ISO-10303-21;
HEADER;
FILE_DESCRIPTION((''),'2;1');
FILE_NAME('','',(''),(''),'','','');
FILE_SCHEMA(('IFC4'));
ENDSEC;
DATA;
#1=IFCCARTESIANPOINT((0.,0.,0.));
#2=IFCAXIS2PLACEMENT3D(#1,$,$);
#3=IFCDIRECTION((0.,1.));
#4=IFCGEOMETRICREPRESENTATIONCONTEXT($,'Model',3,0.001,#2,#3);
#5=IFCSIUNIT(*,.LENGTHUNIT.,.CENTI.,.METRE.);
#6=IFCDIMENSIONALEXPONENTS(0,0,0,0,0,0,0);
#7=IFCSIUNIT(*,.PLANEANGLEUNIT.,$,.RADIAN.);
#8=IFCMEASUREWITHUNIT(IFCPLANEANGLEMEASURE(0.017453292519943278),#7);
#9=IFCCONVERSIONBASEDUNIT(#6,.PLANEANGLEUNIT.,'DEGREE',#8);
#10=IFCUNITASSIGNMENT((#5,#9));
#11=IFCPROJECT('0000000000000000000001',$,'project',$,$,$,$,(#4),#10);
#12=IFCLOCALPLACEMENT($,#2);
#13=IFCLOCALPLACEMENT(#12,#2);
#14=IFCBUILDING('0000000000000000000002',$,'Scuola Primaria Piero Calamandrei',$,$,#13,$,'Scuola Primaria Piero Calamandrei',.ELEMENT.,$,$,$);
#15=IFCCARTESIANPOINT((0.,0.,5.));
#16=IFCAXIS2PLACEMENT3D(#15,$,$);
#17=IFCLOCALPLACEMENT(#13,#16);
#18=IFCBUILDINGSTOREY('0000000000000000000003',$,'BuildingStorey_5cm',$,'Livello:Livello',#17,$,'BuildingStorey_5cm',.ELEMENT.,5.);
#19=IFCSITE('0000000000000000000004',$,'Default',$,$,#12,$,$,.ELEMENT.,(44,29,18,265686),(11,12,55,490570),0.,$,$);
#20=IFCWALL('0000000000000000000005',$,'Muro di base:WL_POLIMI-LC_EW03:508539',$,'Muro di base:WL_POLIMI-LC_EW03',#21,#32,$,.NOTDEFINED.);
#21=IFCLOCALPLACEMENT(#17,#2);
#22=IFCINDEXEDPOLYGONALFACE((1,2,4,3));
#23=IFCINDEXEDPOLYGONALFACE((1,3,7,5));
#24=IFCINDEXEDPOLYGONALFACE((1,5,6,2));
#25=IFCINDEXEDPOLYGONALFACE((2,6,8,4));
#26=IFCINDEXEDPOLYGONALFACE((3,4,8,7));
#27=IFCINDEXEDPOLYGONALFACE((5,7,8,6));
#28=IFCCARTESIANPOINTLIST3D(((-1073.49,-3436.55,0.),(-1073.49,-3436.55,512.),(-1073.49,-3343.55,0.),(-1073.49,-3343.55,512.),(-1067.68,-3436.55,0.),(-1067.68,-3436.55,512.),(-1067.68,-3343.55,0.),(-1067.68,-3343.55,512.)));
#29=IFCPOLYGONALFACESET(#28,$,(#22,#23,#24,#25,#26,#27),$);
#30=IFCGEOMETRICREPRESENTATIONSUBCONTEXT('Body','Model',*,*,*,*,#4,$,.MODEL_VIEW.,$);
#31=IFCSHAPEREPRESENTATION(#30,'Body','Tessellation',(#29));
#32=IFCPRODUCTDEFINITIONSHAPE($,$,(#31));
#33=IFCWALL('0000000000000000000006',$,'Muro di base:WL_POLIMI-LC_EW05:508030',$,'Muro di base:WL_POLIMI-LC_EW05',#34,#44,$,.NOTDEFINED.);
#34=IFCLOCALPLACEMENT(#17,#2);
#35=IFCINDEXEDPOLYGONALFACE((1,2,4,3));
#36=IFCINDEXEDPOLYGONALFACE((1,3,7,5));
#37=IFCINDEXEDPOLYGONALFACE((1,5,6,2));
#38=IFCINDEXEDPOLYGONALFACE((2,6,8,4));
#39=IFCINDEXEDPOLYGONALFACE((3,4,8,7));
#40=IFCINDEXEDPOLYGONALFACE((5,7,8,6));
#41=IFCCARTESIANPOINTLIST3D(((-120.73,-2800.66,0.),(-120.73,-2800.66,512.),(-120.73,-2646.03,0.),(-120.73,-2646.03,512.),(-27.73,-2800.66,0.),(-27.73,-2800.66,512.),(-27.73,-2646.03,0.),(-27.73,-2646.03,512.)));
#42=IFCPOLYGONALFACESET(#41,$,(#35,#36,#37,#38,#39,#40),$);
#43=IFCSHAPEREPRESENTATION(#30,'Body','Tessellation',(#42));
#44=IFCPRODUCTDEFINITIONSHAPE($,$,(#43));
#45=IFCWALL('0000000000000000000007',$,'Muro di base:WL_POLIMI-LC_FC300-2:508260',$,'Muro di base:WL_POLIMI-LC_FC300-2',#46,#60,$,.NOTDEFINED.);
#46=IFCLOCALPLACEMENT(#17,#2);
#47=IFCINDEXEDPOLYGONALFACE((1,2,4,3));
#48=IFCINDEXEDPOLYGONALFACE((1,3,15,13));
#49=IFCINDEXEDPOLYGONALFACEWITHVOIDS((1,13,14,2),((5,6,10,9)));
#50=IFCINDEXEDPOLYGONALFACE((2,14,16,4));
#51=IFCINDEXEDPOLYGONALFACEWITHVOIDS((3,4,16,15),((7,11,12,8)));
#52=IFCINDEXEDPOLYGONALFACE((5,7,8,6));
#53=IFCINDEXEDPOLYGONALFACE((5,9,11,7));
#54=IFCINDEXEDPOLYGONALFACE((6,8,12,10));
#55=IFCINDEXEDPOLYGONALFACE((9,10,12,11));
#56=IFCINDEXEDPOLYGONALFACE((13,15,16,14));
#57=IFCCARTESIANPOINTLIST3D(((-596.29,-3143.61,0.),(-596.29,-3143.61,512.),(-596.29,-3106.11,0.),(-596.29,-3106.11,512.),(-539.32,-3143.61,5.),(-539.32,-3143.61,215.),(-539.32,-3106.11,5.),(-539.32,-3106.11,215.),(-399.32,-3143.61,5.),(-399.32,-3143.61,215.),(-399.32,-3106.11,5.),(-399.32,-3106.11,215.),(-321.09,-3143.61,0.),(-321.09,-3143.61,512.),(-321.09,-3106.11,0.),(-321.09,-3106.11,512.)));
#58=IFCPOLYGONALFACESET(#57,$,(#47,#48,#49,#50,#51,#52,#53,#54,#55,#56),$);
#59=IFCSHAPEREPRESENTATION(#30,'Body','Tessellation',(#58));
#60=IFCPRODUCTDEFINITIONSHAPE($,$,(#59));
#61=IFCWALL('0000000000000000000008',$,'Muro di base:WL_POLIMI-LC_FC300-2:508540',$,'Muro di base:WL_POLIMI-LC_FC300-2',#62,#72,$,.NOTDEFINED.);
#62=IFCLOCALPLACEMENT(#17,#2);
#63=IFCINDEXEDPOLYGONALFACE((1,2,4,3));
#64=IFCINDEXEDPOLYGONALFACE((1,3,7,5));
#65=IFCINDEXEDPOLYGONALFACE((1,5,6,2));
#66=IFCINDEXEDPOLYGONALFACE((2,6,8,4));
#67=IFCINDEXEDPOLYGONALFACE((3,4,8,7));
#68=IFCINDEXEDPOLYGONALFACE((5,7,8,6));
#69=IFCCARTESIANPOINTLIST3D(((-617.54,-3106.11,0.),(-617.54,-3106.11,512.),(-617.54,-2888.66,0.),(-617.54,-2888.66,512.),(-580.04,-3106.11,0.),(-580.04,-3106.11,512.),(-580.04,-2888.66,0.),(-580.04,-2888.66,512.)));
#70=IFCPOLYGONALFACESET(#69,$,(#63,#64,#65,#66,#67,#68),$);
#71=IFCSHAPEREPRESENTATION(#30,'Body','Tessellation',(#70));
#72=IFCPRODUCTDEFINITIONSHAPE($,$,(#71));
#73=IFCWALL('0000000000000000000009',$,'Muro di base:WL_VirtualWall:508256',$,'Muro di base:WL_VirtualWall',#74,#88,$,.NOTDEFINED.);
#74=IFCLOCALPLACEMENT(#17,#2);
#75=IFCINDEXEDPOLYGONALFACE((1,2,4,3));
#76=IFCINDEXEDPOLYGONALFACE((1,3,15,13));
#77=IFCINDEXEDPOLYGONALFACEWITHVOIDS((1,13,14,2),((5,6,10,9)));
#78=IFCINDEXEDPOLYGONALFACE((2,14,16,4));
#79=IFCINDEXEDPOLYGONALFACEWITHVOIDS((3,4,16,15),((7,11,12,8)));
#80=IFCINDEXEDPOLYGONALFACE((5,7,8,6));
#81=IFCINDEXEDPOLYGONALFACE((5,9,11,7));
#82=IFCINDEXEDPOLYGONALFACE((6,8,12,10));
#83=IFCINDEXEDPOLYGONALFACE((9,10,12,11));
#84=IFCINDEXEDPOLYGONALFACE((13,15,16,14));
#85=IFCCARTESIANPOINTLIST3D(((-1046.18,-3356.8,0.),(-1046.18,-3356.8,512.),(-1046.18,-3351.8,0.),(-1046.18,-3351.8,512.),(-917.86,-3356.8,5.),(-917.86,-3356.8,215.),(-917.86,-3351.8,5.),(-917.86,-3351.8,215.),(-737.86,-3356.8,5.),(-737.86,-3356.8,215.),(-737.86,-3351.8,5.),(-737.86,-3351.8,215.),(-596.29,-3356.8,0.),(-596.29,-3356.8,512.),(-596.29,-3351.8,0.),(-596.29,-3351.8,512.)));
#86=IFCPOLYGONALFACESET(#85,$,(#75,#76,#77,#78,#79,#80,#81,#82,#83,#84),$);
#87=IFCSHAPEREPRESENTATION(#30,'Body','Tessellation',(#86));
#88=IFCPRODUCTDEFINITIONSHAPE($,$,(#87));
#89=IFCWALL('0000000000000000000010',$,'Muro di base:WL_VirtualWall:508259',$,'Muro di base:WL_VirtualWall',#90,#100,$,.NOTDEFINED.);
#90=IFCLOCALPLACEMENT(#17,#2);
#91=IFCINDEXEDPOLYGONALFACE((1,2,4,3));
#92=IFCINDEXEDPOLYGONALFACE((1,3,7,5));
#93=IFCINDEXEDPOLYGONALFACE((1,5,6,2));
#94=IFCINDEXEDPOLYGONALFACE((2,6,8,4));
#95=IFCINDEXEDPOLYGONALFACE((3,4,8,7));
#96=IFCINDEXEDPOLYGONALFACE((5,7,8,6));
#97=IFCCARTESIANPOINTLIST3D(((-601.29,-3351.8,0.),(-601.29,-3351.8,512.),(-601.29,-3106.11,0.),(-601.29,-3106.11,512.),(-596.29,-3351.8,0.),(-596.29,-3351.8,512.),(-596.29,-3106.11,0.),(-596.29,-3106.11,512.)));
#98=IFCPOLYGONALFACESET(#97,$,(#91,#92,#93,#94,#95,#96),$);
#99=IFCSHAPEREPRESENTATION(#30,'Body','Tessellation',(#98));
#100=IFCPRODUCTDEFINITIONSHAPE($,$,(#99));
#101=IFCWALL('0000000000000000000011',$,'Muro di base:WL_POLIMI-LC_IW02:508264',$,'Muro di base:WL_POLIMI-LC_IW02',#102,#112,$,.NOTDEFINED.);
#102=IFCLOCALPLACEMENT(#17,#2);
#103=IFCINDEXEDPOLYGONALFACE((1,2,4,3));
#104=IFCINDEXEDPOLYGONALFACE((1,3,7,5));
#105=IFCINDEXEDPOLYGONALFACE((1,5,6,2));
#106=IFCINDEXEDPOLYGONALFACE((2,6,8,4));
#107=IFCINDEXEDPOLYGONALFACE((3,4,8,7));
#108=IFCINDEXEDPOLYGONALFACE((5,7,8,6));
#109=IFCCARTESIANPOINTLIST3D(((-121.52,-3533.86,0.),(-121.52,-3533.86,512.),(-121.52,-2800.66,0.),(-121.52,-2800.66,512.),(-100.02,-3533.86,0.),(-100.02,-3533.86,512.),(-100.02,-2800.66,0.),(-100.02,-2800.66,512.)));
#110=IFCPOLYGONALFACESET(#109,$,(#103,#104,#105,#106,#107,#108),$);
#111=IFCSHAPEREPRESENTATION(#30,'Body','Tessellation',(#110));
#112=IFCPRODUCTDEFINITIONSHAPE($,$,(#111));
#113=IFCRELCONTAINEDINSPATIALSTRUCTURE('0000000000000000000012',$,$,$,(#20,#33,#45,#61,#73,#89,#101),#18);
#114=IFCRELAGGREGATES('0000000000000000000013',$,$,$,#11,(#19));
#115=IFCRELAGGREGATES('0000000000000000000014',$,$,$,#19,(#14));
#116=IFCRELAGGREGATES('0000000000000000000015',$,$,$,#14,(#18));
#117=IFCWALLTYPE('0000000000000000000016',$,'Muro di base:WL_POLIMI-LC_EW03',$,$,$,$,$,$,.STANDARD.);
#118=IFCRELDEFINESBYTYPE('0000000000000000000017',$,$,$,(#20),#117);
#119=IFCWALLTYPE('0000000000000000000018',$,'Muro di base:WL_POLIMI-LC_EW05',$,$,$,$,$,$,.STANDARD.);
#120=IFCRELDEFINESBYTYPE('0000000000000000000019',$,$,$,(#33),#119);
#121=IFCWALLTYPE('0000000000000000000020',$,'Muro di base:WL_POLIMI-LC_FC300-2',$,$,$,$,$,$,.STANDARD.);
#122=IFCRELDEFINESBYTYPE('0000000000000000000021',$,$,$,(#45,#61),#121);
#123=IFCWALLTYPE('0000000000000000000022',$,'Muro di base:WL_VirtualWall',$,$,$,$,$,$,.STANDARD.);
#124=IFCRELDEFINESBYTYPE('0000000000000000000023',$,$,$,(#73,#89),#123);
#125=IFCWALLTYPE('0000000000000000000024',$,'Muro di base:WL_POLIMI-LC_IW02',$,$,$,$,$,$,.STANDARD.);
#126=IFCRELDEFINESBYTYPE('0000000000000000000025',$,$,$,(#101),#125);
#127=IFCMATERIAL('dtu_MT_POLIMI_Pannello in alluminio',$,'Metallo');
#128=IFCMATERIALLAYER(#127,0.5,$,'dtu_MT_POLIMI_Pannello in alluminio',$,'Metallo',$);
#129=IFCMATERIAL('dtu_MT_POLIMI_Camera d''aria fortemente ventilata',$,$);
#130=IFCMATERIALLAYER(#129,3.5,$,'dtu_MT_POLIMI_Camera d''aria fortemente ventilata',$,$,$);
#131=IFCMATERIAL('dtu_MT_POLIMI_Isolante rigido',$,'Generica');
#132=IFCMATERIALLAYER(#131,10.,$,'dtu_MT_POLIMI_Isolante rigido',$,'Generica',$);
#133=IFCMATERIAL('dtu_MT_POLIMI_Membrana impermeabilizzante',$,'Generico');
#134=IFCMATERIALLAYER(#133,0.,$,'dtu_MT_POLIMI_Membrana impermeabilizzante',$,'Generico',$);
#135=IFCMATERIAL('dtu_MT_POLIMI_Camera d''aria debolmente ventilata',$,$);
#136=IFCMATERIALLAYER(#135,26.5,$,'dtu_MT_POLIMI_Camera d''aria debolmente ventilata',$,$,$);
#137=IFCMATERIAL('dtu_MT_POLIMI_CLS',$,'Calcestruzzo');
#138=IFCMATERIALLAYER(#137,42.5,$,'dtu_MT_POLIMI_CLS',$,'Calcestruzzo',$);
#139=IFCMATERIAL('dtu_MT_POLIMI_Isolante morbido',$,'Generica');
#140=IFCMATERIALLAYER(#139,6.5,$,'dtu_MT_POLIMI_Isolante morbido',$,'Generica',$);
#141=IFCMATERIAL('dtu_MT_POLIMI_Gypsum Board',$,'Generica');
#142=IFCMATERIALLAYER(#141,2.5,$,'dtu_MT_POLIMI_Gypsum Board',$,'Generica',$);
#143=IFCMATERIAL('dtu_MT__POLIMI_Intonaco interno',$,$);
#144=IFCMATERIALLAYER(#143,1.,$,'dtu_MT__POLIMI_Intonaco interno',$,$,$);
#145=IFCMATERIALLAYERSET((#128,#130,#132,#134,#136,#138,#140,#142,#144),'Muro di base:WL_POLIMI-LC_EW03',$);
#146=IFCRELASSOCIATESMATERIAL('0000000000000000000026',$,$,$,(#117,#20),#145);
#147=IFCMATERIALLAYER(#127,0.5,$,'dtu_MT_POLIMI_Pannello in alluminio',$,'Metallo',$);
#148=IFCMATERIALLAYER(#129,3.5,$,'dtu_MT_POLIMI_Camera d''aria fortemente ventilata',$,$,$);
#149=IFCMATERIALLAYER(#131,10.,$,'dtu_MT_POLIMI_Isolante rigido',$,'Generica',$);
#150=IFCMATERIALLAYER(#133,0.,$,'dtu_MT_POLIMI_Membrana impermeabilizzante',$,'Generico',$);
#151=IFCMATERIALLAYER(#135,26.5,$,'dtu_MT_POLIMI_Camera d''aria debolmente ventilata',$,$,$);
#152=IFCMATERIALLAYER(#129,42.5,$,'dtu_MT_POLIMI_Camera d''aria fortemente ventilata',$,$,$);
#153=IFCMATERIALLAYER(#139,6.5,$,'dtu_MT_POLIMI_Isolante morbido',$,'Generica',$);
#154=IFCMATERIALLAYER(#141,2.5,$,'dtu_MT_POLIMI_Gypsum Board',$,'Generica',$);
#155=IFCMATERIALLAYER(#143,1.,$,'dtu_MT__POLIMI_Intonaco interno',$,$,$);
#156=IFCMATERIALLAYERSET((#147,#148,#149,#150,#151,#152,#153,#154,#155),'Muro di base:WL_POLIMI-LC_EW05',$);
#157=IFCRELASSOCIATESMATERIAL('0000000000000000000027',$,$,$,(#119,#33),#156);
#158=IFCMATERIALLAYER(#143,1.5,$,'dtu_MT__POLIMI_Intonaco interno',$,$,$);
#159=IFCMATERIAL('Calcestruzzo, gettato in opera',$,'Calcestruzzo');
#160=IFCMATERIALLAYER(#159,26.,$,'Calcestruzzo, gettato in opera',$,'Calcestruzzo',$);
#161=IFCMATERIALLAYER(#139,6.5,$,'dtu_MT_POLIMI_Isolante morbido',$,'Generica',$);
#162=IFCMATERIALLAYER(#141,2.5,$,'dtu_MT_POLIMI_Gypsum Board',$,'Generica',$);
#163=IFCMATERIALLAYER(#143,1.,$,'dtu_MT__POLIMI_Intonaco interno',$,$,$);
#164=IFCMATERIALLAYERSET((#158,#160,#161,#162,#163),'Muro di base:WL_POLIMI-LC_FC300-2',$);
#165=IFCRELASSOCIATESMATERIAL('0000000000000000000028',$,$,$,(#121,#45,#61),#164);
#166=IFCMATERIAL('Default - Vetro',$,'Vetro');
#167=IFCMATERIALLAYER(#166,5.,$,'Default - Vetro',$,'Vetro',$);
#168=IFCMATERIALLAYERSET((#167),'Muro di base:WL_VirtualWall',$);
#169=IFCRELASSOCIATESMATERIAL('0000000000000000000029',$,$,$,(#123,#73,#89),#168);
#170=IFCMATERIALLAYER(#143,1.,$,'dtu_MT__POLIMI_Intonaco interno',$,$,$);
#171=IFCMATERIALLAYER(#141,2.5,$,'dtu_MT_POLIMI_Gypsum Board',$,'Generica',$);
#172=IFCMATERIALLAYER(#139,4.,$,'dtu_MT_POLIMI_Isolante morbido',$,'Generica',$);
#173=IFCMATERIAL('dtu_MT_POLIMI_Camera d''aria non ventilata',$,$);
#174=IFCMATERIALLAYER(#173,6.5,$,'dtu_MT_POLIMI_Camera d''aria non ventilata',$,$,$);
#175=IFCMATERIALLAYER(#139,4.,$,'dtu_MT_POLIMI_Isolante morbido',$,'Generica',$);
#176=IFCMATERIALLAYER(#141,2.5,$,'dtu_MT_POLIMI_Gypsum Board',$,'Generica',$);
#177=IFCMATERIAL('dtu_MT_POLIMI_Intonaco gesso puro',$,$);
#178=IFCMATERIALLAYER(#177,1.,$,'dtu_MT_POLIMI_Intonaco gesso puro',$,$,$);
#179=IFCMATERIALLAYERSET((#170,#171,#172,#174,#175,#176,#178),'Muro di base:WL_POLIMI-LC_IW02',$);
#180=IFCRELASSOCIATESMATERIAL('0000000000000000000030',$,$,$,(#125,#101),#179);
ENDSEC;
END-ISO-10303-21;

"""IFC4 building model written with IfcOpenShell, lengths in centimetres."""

from ifc_helpers import new_model, entity, si_unit, converted_unit, direction, frame, frame_2d, origin, place, context, subcontext, project, spatial, rectangle, extrude, material, layer, layer_set, layer_usage, type_object, element, save


model = new_model("IFC4")

# Units and contexts
model_context = context("Model", 3, precision=0.001, world=origin(), true_north=direction((0.0, 1.0)))
body_context = subcontext(model_context, "Body", "Model", "MODEL_VIEW")
ifc_project = project(units=[si_unit("LENGTHUNIT", "METRE", prefix="CENTI"), converted_unit("PLANEANGLEUNIT", "DEGREE", entity("IfcPlaneAngleMeasure", 0.017453292519943278), si_unit("PLANEANGLEUNIT", "RADIAN"), dimensions=[0, 0, 0, 0, 0, 0, 0])], contexts=[model_context])

# Site, building, storey
site_placement = place(None, origin())
site = spatial("IfcSite", under=ifc_project, at=site_placement, Name="Default", CompositionType="ELEMENT", RefLatitude=(44, 29, 18, 265686), RefLongitude=(11, 12, 55, 490570), RefElevation=0.0)
building_placement = place(site_placement, origin())
building = spatial("IfcBuilding", under=site, at=building_placement, Name="Scuola Primaria Piero Calamandrei", LongName="Scuola Primaria Piero Calamandrei", CompositionType="ELEMENT")
storey_placement = place(building_placement, frame((0.0, 0.0, 5.0)))
storey = spatial("IfcBuildingStorey", under=building, at=storey_placement, Name="BuildingStorey_5cm", ObjectType="Livello:Livello", LongName="BuildingStorey_5cm", CompositionType="ELEMENT", Elevation=5.0)

# Shared definitions
ifc_material_1 = material(Name="Default - Vetro", Category="Vetro")

# Walls
ifc_material_2 = material(Name="dtu_MT_POLIMI_Pannello in alluminio", Category="Metallo")
ifc_layer_1 = layer(ifc_material_2, 0.5, Name="dtu_MT_POLIMI_Pannello in alluminio", Category="Metallo")
ifc_material_3 = material(Name="dtu_MT_POLIMI_Camera d'aria fortemente ventilata")
ifc_layer_2 = layer(ifc_material_3, 3.5, Name="dtu_MT_POLIMI_Camera d'aria fortemente ventilata")
ifc_material_4 = material(Name="dtu_MT_POLIMI_Isolante rigido", Category="Generica")
ifc_layer_3 = layer(ifc_material_4, 10.0, Name="dtu_MT_POLIMI_Isolante rigido", Category="Generica")
ifc_material_5 = material(Name="dtu_MT_POLIMI_Membrana impermeabilizzante", Category="Generico")
ifc_layer_4 = layer(ifc_material_5, 0.0, Name="dtu_MT_POLIMI_Membrana impermeabilizzante", Category="Generico")
ifc_material_6 = material(Name="dtu_MT_POLIMI_Camera d'aria debolmente ventilata")
ifc_layer_5 = layer(ifc_material_6, 26.5, Name="dtu_MT_POLIMI_Camera d'aria debolmente ventilata")
ifc_material_7 = material(Name="dtu_MT_POLIMI_CLS", Category="Calcestruzzo")
ifc_layer_6 = layer(ifc_material_7, 42.5, Name="dtu_MT_POLIMI_CLS", Category="Calcestruzzo")
ifc_material_8 = material(Name="dtu_MT_POLIMI_Isolante morbido", Category="Generica")
ifc_layer_7 = layer(ifc_material_8, 6.5, Name="dtu_MT_POLIMI_Isolante morbido", Category="Generica")
ifc_material_9 = material(Name="dtu_MT_POLIMI_Gypsum Board", Category="Generica")
ifc_layer_8 = layer(ifc_material_9, 2.5, Name="dtu_MT_POLIMI_Gypsum Board", Category="Generica")
ifc_material_10 = material(Name="dtu_MT__POLIMI_Intonaco interno")
ifc_layer_9 = layer(ifc_material_10, 1.0, Name="dtu_MT__POLIMI_Intonaco interno")
ifc_layer_set_1 = layer_set([ifc_layer_1, ifc_layer_2, ifc_layer_3, ifc_layer_4, ifc_layer_5, ifc_layer_6, ifc_layer_7, ifc_layer_8, ifc_layer_9], Name="Muro di base:WL_POLIMI-LC_EW03")
wall_type_1 = type_object("IfcWallType", Name="Muro di base:WL_POLIMI-LC_EW03", PredefinedType="STANDARD", material=ifc_layer_set_1)
ifc_layer_usage_1 = layer_usage(ifc_layer_set_1, "AXIS2", "NEGATIVE", 46.5)
wall_1_placement = place(storey_placement, frame((-1073.49, -3390.05, 0.0)))
element("IfcWall", 1, at=wall_1_placement, inside=storey, type_object=wall_type_1, material=ifc_layer_usage_1, Name="Muro di base:WL_POLIMI-LC_EW03:508539", ObjectType="Muro di base:WL_POLIMI-LC_EW03", PredefinedType="NOTDEFINED", context=body_context, shape_type="SweptSolid", body=[
    extrude(rectangle(XDim=5.81, YDim=93.0, at=frame_2d((2.9, 0.0), x_axis=(-1.0, 0.0))), origin(), (0.0, 0.0, 1.0), 512.0),
])
ifc_layer_10 = layer(ifc_material_2, 0.5, Name="dtu_MT_POLIMI_Pannello in alluminio", Category="Metallo")
ifc_layer_11 = layer(ifc_material_3, 3.5, Name="dtu_MT_POLIMI_Camera d'aria fortemente ventilata")
ifc_layer_12 = layer(ifc_material_4, 10.0, Name="dtu_MT_POLIMI_Isolante rigido", Category="Generica")
ifc_layer_13 = layer(ifc_material_5, 0.0, Name="dtu_MT_POLIMI_Membrana impermeabilizzante", Category="Generico")
ifc_layer_14 = layer(ifc_material_6, 26.5, Name="dtu_MT_POLIMI_Camera d'aria debolmente ventilata")
ifc_layer_15 = layer(ifc_material_3, 42.5, Name="dtu_MT_POLIMI_Camera d'aria fortemente ventilata")
ifc_layer_16 = layer(ifc_material_8, 6.5, Name="dtu_MT_POLIMI_Isolante morbido", Category="Generica")
ifc_layer_17 = layer(ifc_material_9, 2.5, Name="dtu_MT_POLIMI_Gypsum Board", Category="Generica")
ifc_layer_18 = layer(ifc_material_10, 1.0, Name="dtu_MT__POLIMI_Intonaco interno")
ifc_layer_set_2 = layer_set([ifc_layer_10, ifc_layer_11, ifc_layer_12, ifc_layer_13, ifc_layer_14, ifc_layer_15, ifc_layer_16, ifc_layer_17, ifc_layer_18], Name="Muro di base:WL_POLIMI-LC_EW05")
ifc_layer_usage_2 = layer_usage(ifc_layer_set_2, "AXIS2", "NEGATIVE", 46.5)
wall_type_2 = type_object("IfcWallType", Name="Muro di base:WL_POLIMI-LC_EW05", PredefinedType="STANDARD", material=ifc_layer_set_2)
wall_2_placement = place(storey_placement, frame((-74.23, -2800.66, 0.0), z_axis=(0.0, 0.0, 1.0), x_axis=(0.0, 1.0, 0.0)))
element("IfcWall", 2, at=wall_2_placement, inside=storey, type_object=wall_type_2, material=ifc_layer_usage_2, Name="Muro di base:WL_POLIMI-LC_EW05:508030", ObjectType="Muro di base:WL_POLIMI-LC_EW05", PredefinedType="NOTDEFINED", context=body_context, shape_type="SweptSolid", body=[
    extrude(rectangle(XDim=154.63, YDim=93.0, at=frame_2d((77.32, 0.0), x_axis=(-1.0, 0.0))), origin(), (0.0, 0.0, 1.0), 512.0),
])

# Wall, opening
ifc_layer_19 = layer(ifc_material_10, 1.5, Name="dtu_MT__POLIMI_Intonaco interno")
ifc_material_11 = material(Name="Calcestruzzo, gettato in opera", Category="Calcestruzzo")
ifc_layer_20 = layer(ifc_material_11, 26.0, Name="Calcestruzzo, gettato in opera", Category="Calcestruzzo")
ifc_layer_21 = layer(ifc_material_8, 6.5, Name="dtu_MT_POLIMI_Isolante morbido", Category="Generica")
ifc_layer_22 = layer(ifc_material_9, 2.5, Name="dtu_MT_POLIMI_Gypsum Board", Category="Generica")
ifc_layer_23 = layer(ifc_material_10, 1.0, Name="dtu_MT__POLIMI_Intonaco interno")
ifc_layer_set_3 = layer_set([ifc_layer_19, ifc_layer_20, ifc_layer_21, ifc_layer_22, ifc_layer_23], Name="Muro di base:WL_POLIMI-LC_FC300-2")
ifc_layer_usage_3 = layer_usage(ifc_layer_set_3, "AXIS2", "NEGATIVE", 18.75)
wall_type_3 = type_object("IfcWallType", Name="Muro di base:WL_POLIMI-LC_FC300-2", PredefinedType="STANDARD", material=ifc_layer_set_3)
wall_3_placement = place(storey_placement, frame((-596.29, -3124.86, 0.0)))
wall_3 = element("IfcWall", 3, at=wall_3_placement, inside=storey, type_object=wall_type_3, material=ifc_layer_usage_3, Name="Muro di base:WL_POLIMI-LC_FC300-2:508260", ObjectType="Muro di base:WL_POLIMI-LC_FC300-2", PredefinedType="NOTDEFINED", context=body_context, shape_type="SweptSolid", body=[
    extrude(rectangle(XDim=275.2, YDim=37.5, at=frame_2d((137.6, 0.0), x_axis=(-1.0, 0.0))), origin(), (0.0, 0.0, 1.0), 512.0),
])
opening_1_placement = place(wall_3_placement, frame((56.98, -18.75, 5.0)))
element("IfcOpeningElement", 4, at=opening_1_placement, cuts=wall_3, PredefinedType="OPENING", context=body_context, shape_type="SweptSolid", body=[
    extrude(rectangle(XDim=210.0, YDim=140.0, at=frame_2d((105.0, 70.0), x_axis=(1.0, 0.0))), frame((0.0, 0.0, 0.0), z_axis=(0.0, 1.0, 0.0), x_axis=(0.0, 0.0, 1.0)), (0.0, 0.0, 1.0), 37.5),
])

# Wall
ifc_layer_usage_4 = layer_usage(ifc_layer_set_3, "AXIS2", "NEGATIVE", 18.75)
wall_4_placement = place(storey_placement, frame((-598.79, -2888.66, 0.0), z_axis=(0.0, 0.0, 1.0), x_axis=(0.0, -1.0, 0.0)))
element("IfcWall", 5, at=wall_4_placement, inside=storey, type_object=wall_type_3, material=ifc_layer_usage_4, Name="Muro di base:WL_POLIMI-LC_FC300-2:508540", ObjectType="Muro di base:WL_POLIMI-LC_FC300-2", PredefinedType="NOTDEFINED", context=body_context, shape_type="SweptSolid", body=[
    extrude(rectangle(XDim=217.44, YDim=37.5, at=frame_2d((108.72, 0.0), x_axis=(-1.0, 0.0))), origin(), (0.0, 0.0, 1.0), 512.0),
])

# Wall, opening
ifc_layer_24 = layer(ifc_material_1, 5.0, Name="Default - Vetro", Category="Vetro")
ifc_layer_set_4 = layer_set([ifc_layer_24], Name="Muro di base:WL_VirtualWall")
ifc_layer_usage_5 = layer_usage(ifc_layer_set_4, "AXIS2", "NEGATIVE", 2.5)
wall_type_4 = type_object("IfcWallType", Name="Muro di base:WL_VirtualWall", PredefinedType="STANDARD", material=ifc_layer_set_4)
wall_5_placement = place(storey_placement, frame((-1046.18, -3354.3, 0.0)))
wall_5 = element("IfcWall", 6, at=wall_5_placement, inside=storey, type_object=wall_type_4, material=ifc_layer_usage_5, Name="Muro di base:WL_VirtualWall:508256", ObjectType="Muro di base:WL_VirtualWall", PredefinedType="NOTDEFINED", context=body_context, shape_type="SweptSolid", body=[
    extrude(rectangle(XDim=449.89, YDim=5.0, at=frame_2d((224.95, 0.0), x_axis=(-1.0, 0.0))), origin(), (0.0, 0.0, 1.0), 512.0),
])
opening_2_placement = place(wall_5_placement, frame((128.32, -2.5, 5.0)))
element("IfcOpeningElement", 7, at=opening_2_placement, cuts=wall_5, PredefinedType="OPENING", context=body_context, shape_type="SweptSolid", body=[
    extrude(rectangle(XDim=210.0, YDim=180.0, at=frame_2d((105.0, 90.0), x_axis=(1.0, 0.0))), frame((0.0, 0.0, 0.0), z_axis=(0.0, 1.0, 0.0), x_axis=(0.0, 0.0, 1.0)), (0.0, 0.0, 1.0), 5.0),
])

# Walls
ifc_layer_usage_6 = layer_usage(ifc_layer_set_4, "AXIS2", "NEGATIVE", 2.5)
wall_6_placement = place(storey_placement, frame((-598.79, -3351.8, 0.0), z_axis=(0.0, 0.0, 1.0), x_axis=(0.0, 1.0, 0.0)))
element("IfcWall", 8, at=wall_6_placement, inside=storey, type_object=wall_type_4, material=ifc_layer_usage_6, Name="Muro di base:WL_VirtualWall:508259", ObjectType="Muro di base:WL_VirtualWall", PredefinedType="NOTDEFINED", context=body_context, shape_type="SweptSolid", body=[
    extrude(rectangle(XDim=245.69, YDim=5.0, at=frame_2d((122.84, 0.0), x_axis=(-1.0, 0.0))), origin(), (0.0, 0.0, 1.0), 512.0),
])
ifc_layer_25 = layer(ifc_material_10, 1.0, Name="dtu_MT__POLIMI_Intonaco interno")
ifc_layer_26 = layer(ifc_material_9, 2.5, Name="dtu_MT_POLIMI_Gypsum Board", Category="Generica")
ifc_layer_27 = layer(ifc_material_8, 4.0, Name="dtu_MT_POLIMI_Isolante morbido", Category="Generica")
ifc_material_12 = material(Name="dtu_MT_POLIMI_Camera d'aria non ventilata")
ifc_layer_28 = layer(ifc_material_12, 6.5, Name="dtu_MT_POLIMI_Camera d'aria non ventilata")
ifc_layer_29 = layer(ifc_material_8, 4.0, Name="dtu_MT_POLIMI_Isolante morbido", Category="Generica")
ifc_layer_30 = layer(ifc_material_9, 2.5, Name="dtu_MT_POLIMI_Gypsum Board", Category="Generica")
ifc_material_13 = material(Name="dtu_MT_POLIMI_Intonaco gesso puro")
ifc_layer_31 = layer(ifc_material_13, 1.0, Name="dtu_MT_POLIMI_Intonaco gesso puro")
ifc_layer_set_5 = layer_set([ifc_layer_25, ifc_layer_26, ifc_layer_27, ifc_layer_28, ifc_layer_29, ifc_layer_30, ifc_layer_31], Name="Muro di base:WL_POLIMI-LC_IW02")
ifc_layer_usage_7 = layer_usage(ifc_layer_set_5, "AXIS2", "NEGATIVE", 10.75)
wall_type_5 = type_object("IfcWallType", Name="Muro di base:WL_POLIMI-LC_IW02", PredefinedType="STANDARD", material=ifc_layer_set_5)
wall_7_placement = place(storey_placement, frame((-110.77, -2800.66, 0.0), z_axis=(0.0, 0.0, 1.0), x_axis=(0.0, -1.0, 0.0)))
element("IfcWall", 9, at=wall_7_placement, inside=storey, type_object=wall_type_5, material=ifc_layer_usage_7, Name="Muro di base:WL_POLIMI-LC_IW02:508264", ObjectType="Muro di base:WL_POLIMI-LC_IW02", PredefinedType="NOTDEFINED", context=body_context, shape_type="SweptSolid", body=[
    extrude(rectangle(XDim=733.19, YDim=21.5, at=frame_2d((366.6, 0.0), x_axis=(-1.0, 0.0))), origin(), (0.0, 0.0, 1.0), 512.0),
])

save(model, "model.ifc")
